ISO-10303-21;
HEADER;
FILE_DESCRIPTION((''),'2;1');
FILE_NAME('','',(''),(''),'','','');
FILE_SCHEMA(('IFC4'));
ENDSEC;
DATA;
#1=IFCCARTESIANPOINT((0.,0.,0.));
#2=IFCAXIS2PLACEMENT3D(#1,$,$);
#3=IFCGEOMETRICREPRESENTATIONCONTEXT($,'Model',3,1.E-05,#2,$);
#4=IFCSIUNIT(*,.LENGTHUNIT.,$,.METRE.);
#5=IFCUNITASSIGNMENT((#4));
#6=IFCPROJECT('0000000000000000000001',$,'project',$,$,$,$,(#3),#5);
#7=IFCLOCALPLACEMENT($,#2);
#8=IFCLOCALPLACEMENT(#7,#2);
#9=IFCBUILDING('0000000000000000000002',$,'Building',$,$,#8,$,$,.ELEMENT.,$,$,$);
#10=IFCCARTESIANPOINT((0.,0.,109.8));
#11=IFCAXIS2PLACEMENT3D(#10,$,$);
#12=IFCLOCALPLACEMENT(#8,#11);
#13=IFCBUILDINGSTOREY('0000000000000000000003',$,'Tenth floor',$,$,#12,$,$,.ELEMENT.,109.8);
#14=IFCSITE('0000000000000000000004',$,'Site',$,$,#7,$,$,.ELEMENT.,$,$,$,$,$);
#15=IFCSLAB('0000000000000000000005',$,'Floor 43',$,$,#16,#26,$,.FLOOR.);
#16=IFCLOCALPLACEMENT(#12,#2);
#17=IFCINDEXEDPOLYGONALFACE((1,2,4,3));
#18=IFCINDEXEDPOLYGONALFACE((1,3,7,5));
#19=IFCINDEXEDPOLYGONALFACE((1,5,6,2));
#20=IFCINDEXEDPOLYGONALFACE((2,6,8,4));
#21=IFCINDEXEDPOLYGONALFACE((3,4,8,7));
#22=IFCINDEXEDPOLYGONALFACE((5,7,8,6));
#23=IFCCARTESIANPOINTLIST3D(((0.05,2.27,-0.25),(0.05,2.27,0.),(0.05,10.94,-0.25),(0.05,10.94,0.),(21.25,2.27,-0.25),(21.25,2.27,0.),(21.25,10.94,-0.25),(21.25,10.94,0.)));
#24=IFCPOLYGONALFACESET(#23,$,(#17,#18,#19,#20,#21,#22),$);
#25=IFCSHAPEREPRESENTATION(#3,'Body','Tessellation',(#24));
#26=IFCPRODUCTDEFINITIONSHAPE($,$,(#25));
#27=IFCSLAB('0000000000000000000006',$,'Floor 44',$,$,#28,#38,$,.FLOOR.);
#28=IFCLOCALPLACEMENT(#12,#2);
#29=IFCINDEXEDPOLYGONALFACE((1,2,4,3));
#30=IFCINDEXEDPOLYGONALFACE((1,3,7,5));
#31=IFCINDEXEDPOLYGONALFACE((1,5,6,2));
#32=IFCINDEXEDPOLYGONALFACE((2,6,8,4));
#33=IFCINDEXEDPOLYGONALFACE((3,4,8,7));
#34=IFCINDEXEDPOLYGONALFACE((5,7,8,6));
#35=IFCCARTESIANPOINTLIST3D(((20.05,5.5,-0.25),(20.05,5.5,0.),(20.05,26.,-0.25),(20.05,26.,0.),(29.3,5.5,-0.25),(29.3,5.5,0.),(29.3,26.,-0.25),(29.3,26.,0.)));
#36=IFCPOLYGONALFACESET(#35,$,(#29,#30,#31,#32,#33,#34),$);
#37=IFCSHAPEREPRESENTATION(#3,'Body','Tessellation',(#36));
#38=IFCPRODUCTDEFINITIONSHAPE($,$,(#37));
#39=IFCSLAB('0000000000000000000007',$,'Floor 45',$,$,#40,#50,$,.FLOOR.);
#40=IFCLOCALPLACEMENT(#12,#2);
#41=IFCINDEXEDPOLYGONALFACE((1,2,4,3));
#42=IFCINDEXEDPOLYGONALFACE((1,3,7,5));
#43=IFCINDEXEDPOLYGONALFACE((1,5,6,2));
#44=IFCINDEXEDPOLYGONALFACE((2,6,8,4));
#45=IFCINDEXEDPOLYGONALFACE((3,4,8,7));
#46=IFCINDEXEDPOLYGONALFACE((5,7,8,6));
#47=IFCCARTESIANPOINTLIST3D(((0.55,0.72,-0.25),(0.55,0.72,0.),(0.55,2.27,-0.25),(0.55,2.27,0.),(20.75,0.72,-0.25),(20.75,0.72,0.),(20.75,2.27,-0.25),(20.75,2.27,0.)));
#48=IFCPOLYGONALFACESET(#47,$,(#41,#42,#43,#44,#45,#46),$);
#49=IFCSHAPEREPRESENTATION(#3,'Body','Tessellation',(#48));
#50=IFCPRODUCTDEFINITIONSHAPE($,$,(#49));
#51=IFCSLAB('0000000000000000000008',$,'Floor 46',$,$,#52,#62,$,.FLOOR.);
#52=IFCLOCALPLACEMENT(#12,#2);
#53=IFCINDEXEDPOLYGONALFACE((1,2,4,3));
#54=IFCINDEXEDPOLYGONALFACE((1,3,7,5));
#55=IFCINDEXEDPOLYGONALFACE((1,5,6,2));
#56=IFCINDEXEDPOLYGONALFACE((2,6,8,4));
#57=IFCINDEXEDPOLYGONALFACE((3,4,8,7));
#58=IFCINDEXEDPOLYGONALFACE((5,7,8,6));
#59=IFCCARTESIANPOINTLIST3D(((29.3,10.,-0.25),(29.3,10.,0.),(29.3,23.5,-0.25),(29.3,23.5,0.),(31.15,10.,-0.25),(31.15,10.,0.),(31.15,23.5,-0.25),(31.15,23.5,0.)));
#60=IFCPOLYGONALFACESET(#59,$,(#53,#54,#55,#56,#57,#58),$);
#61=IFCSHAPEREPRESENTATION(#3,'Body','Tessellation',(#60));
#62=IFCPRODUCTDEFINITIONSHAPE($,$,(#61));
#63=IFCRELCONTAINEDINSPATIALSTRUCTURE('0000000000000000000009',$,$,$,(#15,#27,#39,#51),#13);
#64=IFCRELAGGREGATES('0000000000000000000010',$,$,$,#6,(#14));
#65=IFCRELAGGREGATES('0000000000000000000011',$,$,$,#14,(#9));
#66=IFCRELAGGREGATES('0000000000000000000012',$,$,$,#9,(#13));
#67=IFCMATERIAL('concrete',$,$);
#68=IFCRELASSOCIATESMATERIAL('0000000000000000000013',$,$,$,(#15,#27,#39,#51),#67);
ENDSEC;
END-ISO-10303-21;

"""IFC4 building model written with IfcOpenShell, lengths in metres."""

from ifc_helpers import new_model, si_unit, frame, origin, place, context, project, spatial, polyline, outline, extrude, material, element, save


model = new_model("IFC4")

# Units and contexts
model_context = context("Model", 3, precision=1e-05, world=origin())
ifc_project = project(units=[si_unit("LENGTHUNIT", "METRE")], contexts=[model_context])

# Site, building, storey
site_placement = place(None, origin())
site = spatial("IfcSite", under=ifc_project, at=site_placement, Name="Site", CompositionType="ELEMENT")
building_placement = place(site_placement, origin())
building = spatial("IfcBuilding", under=site, at=building_placement, Name="Building", CompositionType="ELEMENT")
storey_placement = place(building_placement, frame((0.0, 0.0, 109.8)))
storey = spatial("IfcBuildingStorey", under=building, at=storey_placement, Name="Tenth floor", CompositionType="ELEMENT", Elevation=109.8)

# Slabs
ifc_material = material(Name="concrete")
slab_1_placement = place(storey_placement, frame((0.0, 0.0, -0.25), z_axis=(0.0, 0.0, 1.0), x_axis=(1.0, 0.0, 0.0)))
element("IfcSlab", 1, at=slab_1_placement, inside=storey, material=ifc_material, Name="Floor 43", PredefinedType="FLOOR", context=model_context, shape_type="SweptSolid", body=[
    extrude(outline(polyline([(0.05, 2.27), (21.25, 2.27), (21.25, 10.94), (0.05, 10.94), (0.05, 2.27)])), origin(), (0.0, 0.0, 1.0), 0.25),
])
slab_2_placement = place(storey_placement, frame((0.0, 0.0, -0.25), z_axis=(0.0, 0.0, 1.0), x_axis=(1.0, 0.0, 0.0)))
element("IfcSlab", 2, at=slab_2_placement, inside=storey, material=ifc_material, Name="Floor 44", PredefinedType="FLOOR", context=model_context, shape_type="SweptSolid", body=[
    extrude(outline(polyline([(20.05, 5.5), (29.3, 5.5), (29.3, 26.0), (20.05, 26.0), (20.05, 5.5)])), origin(), (0.0, 0.0, 1.0), 0.25),
])
slab_3_placement = place(storey_placement, frame((0.0, 0.0, -0.25), z_axis=(0.0, 0.0, 1.0), x_axis=(1.0, 0.0, 0.0)))
element("IfcSlab", 3, at=slab_3_placement, inside=storey, material=ifc_material, Name="Floor 45", PredefinedType="FLOOR", context=model_context, shape_type="SweptSolid", body=[
    extrude(outline(polyline([(0.55, 0.72), (20.75, 0.72), (20.75, 2.27), (0.55, 2.27), (0.55, 0.72)])), origin(), (0.0, 0.0, 1.0), 0.25),
])
slab_4_placement = place(storey_placement, frame((0.0, 0.0, -0.25), z_axis=(0.0, 0.0, 1.0), x_axis=(1.0, 0.0, 0.0)))
element("IfcSlab", 4, at=slab_4_placement, inside=storey, material=ifc_material, Name="Floor 46", PredefinedType="FLOOR", context=model_context, shape_type="SweptSolid", body=[
    extrude(outline(polyline([(29.3, 10.0), (31.15, 10.0), (31.15, 23.5), (29.3, 23.5), (29.3, 10.0)])), origin(), (0.0, 0.0, 1.0), 0.25),
])

save(model, "model.ifc")
